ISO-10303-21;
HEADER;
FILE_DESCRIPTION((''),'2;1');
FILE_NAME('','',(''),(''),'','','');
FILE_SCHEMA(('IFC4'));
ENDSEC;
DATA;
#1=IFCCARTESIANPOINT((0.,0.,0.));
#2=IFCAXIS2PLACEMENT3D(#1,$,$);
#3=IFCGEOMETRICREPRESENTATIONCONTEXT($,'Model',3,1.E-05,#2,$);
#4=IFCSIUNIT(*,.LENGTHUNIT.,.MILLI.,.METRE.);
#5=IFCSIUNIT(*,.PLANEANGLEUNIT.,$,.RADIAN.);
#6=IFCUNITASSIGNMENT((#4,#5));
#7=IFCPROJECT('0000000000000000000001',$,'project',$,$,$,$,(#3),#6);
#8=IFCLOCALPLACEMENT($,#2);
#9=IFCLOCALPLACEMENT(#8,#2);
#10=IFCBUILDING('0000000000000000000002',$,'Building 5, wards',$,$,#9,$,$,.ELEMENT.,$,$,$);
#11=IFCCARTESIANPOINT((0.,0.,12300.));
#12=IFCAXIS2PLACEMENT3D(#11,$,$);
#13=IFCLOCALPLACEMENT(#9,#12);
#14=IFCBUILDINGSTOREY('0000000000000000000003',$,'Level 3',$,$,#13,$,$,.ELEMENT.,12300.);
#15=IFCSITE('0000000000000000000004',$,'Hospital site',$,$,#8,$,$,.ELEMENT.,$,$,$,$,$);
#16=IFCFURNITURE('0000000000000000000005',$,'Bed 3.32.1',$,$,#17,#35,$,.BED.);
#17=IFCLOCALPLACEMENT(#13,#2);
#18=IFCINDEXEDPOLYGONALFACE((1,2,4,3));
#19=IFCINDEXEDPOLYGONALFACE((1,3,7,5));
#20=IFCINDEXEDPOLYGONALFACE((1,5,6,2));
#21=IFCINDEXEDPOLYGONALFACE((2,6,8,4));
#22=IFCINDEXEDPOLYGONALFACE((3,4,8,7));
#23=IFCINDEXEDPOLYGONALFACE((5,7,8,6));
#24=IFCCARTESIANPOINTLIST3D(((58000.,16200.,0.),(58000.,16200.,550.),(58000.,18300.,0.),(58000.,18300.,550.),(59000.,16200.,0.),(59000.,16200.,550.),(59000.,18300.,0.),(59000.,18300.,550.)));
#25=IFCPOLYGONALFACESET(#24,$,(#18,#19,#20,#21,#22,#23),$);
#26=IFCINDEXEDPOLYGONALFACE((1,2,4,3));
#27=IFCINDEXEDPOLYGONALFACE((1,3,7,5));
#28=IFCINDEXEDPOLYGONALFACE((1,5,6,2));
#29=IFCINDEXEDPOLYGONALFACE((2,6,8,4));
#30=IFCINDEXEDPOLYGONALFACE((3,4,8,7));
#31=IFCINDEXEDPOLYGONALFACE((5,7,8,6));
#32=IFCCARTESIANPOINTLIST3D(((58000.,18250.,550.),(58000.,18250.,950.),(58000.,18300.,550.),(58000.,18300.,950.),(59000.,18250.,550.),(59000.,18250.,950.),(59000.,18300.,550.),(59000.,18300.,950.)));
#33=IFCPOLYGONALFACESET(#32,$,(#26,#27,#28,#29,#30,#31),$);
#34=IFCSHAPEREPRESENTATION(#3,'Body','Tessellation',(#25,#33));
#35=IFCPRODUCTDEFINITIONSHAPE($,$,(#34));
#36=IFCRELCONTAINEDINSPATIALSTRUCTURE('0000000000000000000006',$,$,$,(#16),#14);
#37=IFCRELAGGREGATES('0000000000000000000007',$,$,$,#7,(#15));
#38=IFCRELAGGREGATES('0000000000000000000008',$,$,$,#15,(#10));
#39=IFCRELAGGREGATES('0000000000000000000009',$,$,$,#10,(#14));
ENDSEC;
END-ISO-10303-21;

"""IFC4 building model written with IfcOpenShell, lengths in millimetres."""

from ifc_helpers import new_model, si_unit, frame, frame_2d, origin, place, context, project, spatial, rectangle, extrude, element, save


model = new_model("IFC4")

# Units and contexts
model_context = context("Model", 3, precision=1e-05, world=origin())
ifc_project = project(units=[si_unit("LENGTHUNIT", "METRE", prefix="MILLI"), si_unit("PLANEANGLEUNIT", "RADIAN")], contexts=[model_context])

# Site, building, storey
site_placement = place(None, origin())
site = spatial("IfcSite", under=ifc_project, at=site_placement, Name="Hospital site", CompositionType="ELEMENT")
building_placement = place(site_placement, origin())
building = spatial("IfcBuilding", under=site, at=building_placement, Name="Building 5, wards", CompositionType="ELEMENT")
storey_placement = place(building_placement, frame((0.0, 0.0, 12300.0)))
storey = spatial("IfcBuildingStorey", under=building, at=storey_placement, Name="Level 3", CompositionType="ELEMENT", Elevation=12300.0)

# Furniture
furniture_placement = place(storey_placement, frame((58000.0, 16200.0, 0.0)))
element("IfcFurniture", 1, at=furniture_placement, inside=storey, Name="Bed 3.32.1", PredefinedType="BED", context=model_context, shape_type="SweptSolid", body=[
    extrude(rectangle(XDim=1000.0, YDim=2100.0, at=frame_2d((500.0, 1050.0))), origin(), (0.0, 0.0, 1.0), 550.0),
    extrude(rectangle(XDim=1000.0, YDim=50.0, at=frame_2d((500.0, 2075.0))), frame((0.0, 0.0, 550.0)), (0.0, 0.0, 1.0), 400.0),
])

save(model, "model.ifc")
